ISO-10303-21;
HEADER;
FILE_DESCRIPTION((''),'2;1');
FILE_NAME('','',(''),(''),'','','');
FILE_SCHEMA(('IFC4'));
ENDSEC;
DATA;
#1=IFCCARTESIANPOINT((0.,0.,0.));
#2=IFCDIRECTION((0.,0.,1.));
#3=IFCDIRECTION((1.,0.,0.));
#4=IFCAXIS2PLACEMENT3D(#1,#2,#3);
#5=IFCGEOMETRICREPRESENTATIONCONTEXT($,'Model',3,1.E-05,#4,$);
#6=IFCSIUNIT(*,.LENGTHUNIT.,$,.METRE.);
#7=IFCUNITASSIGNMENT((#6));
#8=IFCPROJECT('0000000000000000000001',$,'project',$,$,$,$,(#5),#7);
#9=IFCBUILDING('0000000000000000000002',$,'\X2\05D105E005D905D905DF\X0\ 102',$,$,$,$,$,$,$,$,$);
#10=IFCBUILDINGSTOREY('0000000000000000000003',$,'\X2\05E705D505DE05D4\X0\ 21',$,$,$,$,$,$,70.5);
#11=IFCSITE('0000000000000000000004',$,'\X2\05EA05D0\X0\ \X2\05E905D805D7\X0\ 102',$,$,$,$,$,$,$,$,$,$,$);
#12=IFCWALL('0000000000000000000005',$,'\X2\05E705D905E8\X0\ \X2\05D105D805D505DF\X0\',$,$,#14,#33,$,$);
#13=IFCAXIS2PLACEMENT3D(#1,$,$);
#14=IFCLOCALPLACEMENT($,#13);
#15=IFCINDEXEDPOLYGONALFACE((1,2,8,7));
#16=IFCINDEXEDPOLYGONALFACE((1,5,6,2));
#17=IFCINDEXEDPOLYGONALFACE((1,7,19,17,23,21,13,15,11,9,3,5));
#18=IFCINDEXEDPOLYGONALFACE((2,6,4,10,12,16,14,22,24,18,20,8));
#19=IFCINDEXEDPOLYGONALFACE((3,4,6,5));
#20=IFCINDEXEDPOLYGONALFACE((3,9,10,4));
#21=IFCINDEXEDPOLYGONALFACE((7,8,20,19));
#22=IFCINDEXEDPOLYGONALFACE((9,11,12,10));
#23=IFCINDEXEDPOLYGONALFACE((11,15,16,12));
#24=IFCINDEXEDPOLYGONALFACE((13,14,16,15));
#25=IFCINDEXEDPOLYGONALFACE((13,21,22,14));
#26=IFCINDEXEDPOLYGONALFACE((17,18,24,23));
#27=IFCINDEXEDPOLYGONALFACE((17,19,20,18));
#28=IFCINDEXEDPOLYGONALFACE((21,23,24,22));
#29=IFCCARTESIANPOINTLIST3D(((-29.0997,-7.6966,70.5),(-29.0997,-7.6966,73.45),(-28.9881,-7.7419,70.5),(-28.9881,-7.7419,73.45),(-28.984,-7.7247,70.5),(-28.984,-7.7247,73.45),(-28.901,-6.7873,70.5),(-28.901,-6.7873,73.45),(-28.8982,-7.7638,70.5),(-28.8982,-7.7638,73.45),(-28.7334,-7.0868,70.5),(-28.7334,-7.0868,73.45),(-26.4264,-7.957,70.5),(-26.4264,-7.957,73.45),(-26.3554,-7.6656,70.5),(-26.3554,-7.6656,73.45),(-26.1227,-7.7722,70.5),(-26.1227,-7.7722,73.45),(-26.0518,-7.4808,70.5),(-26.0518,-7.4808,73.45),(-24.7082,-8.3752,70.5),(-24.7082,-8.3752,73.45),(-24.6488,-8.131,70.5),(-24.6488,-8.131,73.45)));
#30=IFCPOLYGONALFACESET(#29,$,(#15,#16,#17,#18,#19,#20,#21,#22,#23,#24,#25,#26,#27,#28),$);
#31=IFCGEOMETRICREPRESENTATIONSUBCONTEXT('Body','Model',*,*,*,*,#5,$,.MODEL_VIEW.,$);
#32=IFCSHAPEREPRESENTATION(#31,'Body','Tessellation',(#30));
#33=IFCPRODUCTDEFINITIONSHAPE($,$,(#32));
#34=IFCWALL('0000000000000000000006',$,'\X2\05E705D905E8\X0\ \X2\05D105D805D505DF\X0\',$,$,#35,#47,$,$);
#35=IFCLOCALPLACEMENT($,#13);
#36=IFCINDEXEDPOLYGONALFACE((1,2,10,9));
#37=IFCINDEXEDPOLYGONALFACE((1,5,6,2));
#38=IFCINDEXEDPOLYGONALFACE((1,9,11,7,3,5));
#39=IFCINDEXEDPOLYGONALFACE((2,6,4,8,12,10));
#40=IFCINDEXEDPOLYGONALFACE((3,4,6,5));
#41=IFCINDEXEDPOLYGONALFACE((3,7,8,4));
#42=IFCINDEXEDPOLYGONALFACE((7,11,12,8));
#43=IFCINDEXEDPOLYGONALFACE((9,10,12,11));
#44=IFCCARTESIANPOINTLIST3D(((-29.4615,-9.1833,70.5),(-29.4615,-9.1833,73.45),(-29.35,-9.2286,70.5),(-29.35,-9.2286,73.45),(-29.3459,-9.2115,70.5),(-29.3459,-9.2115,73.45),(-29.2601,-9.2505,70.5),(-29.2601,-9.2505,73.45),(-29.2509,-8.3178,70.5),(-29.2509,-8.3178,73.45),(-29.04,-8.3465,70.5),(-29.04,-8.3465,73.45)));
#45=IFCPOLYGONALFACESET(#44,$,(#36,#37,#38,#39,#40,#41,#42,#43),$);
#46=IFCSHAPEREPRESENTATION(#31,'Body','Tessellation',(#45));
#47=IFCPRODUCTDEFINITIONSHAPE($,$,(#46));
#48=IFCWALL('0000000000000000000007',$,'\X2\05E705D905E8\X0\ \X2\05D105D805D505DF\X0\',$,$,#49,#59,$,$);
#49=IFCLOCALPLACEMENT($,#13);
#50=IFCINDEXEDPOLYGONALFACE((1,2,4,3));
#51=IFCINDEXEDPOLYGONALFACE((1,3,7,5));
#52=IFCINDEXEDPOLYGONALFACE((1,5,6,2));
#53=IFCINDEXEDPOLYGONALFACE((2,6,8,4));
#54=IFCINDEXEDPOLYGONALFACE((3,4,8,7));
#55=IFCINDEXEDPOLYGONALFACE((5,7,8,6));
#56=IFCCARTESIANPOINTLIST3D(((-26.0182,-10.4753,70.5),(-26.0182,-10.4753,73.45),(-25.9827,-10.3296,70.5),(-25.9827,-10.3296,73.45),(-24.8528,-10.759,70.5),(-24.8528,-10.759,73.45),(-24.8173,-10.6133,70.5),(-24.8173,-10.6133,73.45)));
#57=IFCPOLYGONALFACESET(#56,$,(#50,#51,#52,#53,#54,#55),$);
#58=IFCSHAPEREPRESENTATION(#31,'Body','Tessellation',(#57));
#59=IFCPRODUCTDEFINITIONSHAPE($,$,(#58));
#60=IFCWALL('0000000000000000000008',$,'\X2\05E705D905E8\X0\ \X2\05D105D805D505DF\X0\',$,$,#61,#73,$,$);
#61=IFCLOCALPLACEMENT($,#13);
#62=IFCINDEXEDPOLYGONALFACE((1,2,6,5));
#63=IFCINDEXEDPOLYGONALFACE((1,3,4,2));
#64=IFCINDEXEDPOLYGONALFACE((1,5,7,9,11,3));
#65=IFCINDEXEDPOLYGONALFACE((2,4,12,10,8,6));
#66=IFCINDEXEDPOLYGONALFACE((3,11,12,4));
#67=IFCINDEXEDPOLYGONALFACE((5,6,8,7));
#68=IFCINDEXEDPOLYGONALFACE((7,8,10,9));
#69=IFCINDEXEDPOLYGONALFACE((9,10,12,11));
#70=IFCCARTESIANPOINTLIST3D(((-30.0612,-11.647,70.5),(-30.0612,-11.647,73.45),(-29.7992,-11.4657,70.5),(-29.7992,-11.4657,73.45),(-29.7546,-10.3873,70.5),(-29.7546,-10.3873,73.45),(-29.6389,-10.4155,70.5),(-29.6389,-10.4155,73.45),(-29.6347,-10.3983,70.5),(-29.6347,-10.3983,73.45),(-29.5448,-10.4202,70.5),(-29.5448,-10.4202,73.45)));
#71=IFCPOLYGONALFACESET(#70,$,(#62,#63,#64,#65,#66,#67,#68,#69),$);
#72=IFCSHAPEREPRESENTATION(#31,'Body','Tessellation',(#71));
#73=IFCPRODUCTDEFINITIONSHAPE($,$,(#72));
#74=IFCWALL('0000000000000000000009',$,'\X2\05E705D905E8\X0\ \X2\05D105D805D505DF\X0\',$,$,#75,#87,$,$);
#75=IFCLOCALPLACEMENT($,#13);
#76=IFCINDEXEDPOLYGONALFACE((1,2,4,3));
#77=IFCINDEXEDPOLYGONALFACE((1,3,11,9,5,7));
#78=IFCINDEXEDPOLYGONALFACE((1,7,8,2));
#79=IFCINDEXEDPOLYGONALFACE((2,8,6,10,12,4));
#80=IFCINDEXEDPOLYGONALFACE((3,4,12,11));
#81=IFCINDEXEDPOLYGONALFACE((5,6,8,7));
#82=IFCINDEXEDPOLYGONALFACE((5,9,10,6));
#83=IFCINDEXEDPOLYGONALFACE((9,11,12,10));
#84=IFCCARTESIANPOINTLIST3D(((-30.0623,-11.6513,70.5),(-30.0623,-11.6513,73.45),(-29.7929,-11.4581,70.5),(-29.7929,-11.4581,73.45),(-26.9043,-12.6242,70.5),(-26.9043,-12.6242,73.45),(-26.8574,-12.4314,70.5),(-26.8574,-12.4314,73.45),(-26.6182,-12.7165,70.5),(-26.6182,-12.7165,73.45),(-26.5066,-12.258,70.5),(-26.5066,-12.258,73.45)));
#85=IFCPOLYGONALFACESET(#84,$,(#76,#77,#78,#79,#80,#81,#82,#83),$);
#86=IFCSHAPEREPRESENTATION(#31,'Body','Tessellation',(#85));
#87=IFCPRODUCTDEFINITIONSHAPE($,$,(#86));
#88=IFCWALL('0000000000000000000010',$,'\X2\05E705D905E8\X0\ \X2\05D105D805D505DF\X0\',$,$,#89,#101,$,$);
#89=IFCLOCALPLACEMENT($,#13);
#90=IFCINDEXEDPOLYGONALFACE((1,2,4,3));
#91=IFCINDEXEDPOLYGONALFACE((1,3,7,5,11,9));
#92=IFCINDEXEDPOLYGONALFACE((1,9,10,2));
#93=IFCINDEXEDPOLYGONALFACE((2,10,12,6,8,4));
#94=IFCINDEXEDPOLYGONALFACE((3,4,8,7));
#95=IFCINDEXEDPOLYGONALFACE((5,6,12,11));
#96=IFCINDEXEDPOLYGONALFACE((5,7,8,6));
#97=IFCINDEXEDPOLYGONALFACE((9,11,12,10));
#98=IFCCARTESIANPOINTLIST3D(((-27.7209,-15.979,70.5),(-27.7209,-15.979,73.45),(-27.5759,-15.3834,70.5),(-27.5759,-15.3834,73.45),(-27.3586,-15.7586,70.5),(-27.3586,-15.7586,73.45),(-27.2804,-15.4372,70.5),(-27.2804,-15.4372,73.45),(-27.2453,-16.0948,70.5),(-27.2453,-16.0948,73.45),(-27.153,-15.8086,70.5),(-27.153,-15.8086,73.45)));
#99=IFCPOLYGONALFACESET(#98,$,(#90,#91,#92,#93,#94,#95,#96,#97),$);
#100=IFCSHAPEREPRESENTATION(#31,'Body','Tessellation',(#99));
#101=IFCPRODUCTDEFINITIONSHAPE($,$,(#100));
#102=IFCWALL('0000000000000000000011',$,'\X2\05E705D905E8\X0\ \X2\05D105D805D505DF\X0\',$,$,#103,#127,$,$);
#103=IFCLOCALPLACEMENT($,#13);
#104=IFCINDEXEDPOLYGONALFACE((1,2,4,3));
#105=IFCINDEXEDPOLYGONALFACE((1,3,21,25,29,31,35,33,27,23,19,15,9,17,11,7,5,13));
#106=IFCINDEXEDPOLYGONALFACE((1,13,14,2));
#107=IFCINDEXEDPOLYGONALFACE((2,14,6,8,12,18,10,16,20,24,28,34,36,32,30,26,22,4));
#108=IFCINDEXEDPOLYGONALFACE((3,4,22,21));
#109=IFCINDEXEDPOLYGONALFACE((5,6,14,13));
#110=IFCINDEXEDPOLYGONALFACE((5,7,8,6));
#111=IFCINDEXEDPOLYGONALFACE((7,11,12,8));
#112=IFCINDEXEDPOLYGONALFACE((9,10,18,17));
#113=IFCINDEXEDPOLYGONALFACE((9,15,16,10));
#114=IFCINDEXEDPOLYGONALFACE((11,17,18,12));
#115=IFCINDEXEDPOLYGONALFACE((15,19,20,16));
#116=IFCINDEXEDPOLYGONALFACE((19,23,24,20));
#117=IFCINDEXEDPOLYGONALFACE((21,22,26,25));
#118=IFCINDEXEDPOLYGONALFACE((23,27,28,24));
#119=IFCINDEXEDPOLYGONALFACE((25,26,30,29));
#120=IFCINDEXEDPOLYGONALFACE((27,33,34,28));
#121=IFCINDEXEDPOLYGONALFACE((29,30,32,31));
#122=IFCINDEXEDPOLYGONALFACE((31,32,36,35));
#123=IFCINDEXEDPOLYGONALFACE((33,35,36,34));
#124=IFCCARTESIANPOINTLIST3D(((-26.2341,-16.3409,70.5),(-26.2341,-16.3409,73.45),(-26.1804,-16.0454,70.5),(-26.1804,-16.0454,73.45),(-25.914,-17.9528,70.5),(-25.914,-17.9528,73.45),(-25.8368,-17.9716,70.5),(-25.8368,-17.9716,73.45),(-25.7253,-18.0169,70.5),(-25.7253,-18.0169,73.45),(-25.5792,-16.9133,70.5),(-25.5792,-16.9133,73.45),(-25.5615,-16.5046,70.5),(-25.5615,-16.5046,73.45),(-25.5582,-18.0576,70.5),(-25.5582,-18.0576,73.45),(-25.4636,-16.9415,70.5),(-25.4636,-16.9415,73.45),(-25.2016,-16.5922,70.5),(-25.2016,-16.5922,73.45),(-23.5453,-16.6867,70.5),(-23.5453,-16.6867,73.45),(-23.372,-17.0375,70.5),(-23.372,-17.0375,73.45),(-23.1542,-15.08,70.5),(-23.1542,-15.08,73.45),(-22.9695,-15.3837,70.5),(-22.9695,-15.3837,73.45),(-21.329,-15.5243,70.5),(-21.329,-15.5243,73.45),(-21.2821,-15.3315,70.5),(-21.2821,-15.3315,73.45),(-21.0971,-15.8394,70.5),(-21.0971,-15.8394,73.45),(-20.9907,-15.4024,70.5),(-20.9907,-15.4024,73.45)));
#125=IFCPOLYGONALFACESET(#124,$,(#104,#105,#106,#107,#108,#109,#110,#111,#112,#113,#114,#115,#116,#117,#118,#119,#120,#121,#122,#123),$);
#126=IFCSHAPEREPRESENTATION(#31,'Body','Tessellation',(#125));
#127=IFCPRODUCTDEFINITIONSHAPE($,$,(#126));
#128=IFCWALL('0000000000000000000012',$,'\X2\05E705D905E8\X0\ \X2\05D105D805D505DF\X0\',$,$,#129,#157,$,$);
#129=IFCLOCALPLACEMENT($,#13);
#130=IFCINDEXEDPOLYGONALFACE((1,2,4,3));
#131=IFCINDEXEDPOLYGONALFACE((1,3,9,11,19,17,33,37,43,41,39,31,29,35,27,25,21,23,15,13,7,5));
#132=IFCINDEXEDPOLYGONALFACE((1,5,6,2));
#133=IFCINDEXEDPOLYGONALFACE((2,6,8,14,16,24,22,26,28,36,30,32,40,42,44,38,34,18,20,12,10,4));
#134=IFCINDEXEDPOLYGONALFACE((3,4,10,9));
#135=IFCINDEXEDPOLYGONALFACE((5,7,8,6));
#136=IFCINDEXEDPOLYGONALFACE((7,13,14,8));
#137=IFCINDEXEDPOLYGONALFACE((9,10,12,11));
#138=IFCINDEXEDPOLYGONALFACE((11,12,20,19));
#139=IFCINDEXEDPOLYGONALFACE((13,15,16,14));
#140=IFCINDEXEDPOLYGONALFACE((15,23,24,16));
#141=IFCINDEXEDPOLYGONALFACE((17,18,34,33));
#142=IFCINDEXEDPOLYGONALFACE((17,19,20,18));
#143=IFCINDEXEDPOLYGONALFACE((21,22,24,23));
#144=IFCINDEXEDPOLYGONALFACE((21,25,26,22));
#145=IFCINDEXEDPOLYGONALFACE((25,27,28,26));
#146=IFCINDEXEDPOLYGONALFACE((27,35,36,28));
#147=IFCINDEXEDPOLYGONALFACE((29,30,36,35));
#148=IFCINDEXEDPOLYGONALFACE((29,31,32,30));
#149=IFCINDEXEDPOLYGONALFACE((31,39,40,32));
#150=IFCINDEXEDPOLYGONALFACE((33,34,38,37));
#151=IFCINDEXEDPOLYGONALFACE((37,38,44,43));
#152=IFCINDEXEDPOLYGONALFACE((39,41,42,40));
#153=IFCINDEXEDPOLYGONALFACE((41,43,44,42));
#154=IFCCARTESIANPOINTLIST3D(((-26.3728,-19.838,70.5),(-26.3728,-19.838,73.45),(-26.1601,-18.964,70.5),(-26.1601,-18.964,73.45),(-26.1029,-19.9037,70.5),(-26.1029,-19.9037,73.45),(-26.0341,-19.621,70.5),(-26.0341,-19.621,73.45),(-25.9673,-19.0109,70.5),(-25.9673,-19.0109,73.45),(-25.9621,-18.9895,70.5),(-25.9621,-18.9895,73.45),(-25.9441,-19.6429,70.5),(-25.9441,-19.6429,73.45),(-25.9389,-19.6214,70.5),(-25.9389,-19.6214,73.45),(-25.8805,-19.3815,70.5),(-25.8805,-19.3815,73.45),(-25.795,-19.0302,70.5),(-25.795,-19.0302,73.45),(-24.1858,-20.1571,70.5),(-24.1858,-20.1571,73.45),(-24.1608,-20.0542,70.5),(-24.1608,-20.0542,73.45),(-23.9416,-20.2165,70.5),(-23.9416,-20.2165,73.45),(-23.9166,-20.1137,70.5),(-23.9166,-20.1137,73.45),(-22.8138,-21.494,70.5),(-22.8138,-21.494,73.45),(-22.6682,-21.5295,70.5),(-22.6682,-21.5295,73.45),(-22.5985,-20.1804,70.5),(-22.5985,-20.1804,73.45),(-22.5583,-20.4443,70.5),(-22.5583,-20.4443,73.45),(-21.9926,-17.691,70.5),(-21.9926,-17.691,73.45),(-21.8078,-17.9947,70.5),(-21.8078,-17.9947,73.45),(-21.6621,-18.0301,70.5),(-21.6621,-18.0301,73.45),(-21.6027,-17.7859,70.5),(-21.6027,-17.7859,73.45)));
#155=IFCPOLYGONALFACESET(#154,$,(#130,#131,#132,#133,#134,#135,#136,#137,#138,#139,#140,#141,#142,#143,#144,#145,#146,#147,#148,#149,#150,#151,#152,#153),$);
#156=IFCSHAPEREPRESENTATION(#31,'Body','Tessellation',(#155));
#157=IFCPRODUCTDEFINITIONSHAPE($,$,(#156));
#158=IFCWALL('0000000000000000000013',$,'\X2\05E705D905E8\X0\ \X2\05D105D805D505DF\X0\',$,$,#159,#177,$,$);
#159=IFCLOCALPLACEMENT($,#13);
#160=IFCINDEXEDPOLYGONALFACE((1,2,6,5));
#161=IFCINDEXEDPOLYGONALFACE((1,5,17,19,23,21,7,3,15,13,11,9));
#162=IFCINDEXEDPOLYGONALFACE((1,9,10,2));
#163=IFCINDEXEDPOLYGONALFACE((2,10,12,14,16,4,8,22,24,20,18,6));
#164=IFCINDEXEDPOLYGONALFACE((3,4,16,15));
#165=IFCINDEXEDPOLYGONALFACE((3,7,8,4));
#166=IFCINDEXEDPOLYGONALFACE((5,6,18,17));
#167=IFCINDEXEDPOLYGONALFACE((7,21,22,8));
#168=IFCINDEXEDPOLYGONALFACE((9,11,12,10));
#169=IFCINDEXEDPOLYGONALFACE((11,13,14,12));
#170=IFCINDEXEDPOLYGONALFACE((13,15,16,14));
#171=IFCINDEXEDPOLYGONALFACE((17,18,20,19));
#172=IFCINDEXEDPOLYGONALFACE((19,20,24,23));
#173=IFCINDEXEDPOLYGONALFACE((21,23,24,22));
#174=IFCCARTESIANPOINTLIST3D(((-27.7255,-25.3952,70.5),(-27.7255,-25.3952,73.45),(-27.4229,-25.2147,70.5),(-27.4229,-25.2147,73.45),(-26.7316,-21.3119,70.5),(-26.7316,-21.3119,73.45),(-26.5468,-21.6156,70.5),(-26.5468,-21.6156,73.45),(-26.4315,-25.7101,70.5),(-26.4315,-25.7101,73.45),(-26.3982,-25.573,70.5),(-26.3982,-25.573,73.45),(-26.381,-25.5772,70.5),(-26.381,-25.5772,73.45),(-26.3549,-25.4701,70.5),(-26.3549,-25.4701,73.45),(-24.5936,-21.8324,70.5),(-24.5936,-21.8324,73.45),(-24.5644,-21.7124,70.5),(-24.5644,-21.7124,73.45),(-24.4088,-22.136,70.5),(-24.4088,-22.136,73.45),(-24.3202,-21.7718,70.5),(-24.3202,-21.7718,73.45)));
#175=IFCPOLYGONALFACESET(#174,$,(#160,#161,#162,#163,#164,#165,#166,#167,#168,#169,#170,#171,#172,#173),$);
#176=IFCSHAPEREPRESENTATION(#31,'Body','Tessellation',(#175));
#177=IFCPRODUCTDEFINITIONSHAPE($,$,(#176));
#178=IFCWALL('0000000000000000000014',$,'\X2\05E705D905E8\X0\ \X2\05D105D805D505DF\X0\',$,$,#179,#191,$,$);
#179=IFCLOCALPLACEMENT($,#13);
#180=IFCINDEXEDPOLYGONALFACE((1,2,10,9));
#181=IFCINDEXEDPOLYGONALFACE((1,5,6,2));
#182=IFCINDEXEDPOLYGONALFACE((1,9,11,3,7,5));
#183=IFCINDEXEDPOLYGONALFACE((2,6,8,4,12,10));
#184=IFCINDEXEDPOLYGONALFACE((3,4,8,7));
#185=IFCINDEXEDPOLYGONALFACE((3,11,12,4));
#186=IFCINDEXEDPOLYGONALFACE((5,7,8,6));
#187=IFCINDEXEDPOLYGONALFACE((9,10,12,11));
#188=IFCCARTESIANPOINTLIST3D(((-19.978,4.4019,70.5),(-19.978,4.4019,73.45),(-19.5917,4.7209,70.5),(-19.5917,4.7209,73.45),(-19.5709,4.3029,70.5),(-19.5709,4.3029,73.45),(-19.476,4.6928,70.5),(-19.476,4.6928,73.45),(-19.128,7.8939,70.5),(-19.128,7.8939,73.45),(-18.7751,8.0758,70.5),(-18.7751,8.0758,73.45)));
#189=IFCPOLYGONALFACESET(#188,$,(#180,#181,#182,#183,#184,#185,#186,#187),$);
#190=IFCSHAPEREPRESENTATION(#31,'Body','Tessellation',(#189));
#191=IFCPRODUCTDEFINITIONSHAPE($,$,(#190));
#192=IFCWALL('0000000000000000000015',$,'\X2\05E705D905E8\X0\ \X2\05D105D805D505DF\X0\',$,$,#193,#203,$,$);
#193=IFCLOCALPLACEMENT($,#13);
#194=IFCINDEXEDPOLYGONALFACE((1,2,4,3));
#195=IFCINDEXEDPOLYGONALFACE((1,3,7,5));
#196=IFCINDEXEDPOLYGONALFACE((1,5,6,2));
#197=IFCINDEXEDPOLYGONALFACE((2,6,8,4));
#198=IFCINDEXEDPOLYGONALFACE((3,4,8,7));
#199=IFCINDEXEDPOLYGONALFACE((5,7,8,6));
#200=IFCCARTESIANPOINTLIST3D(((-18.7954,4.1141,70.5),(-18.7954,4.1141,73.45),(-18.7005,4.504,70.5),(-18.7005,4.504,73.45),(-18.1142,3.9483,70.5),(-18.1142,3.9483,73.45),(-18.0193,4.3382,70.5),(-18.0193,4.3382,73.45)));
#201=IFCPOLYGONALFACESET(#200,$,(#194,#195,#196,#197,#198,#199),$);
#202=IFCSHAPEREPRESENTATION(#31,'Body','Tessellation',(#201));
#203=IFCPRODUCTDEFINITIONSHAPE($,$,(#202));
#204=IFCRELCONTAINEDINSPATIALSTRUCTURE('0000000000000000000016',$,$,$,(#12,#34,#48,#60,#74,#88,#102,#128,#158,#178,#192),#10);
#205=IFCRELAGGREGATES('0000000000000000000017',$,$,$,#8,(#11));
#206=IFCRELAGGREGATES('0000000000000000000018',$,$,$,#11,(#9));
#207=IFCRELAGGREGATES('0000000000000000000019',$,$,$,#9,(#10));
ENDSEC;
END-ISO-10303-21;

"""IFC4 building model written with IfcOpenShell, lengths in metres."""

from ifc_helpers import new_model, si_unit, frame, origin_with_axes, context, subcontext, project, spatial, polyline, outline, extrude, element, save


model = new_model("IFC4")

# Units and contexts
model_context = context("Model", 3, precision=1e-05, world=origin_with_axes())
body_context = subcontext(model_context, "Body", "Model", "MODEL_VIEW")
ifc_project = project(units=[si_unit("LENGTHUNIT", "METRE")], contexts=[model_context])

# Site, building, storey
site = spatial("IfcSite", under=ifc_project, Name="תא שטח 102")
building = spatial("IfcBuilding", under=site, Name="בניין 102")
storey = spatial("IfcBuildingStorey", under=building, Name="קומה 21", Elevation=70.5)

# Walls
element("IfcWall", 1, inside=storey, Name="קיר בטון", context=body_context, shape_type="SweptSolid", body=[
    extrude(outline(polyline([(-28.984, -7.7247), (-28.9881, -7.7419), (-28.8982, -7.7638), (-28.7334, -7.0868), (-26.3554, -7.6656), (-26.4264, -7.957), (-24.7082, -8.3752), (-24.6488, -8.131), (-26.1227, -7.7722), (-26.0518, -7.4808), (-28.901, -6.7873), (-29.0997, -7.6966), (-28.984, -7.7247)])), frame((0.0, 0.0, 70.5)), (0.0, 0.0, 1.0), 2.95),
])
element("IfcWall", 2, inside=storey, Name="קיר בטון", context=body_context, shape_type="SweptSolid", body=[
    extrude(outline(polyline([(-29.3459, -9.2115), (-29.35, -9.2286), (-29.2601, -9.2505), (-29.04, -8.3465), (-29.2509, -8.3178), (-29.4615, -9.1833), (-29.3459, -9.2115)])), frame((0.0, 0.0, 70.5)), (0.0, 0.0, 1.0), 2.95),
])
element("IfcWall", 3, inside=storey, Name="קיר בטון", context=body_context, shape_type="SweptSolid", body=[
    extrude(outline(polyline([(-25.9827, -10.3296), (-26.0182, -10.4753), (-24.8528, -10.759), (-24.8173, -10.6133), (-25.9827, -10.3296)])), frame((0.0, 0.0, 70.5)), (0.0, 0.0, 1.0), 2.95),
])
element("IfcWall", 4, inside=storey, Name="קיר בטון", context=body_context, shape_type="SweptSolid", body=[
    extrude(outline(polyline([(-29.7992, -11.4657), (-29.5448, -10.4202), (-29.6347, -10.3983), (-29.6389, -10.4155), (-29.7546, -10.3873), (-30.0612, -11.647), (-29.7992, -11.4657)])), frame((0.0, 0.0, 70.5)), (0.0, 0.0, 1.0), 2.95),
])
element("IfcWall", 5, inside=storey, Name="קיר בטון", context=body_context, shape_type="SweptSolid", body=[
    extrude(outline(polyline([(-26.5066, -12.258), (-29.7929, -11.4581), (-30.0623, -11.6513), (-26.8574, -12.4314), (-26.9043, -12.6242), (-26.6182, -12.7165), (-26.5066, -12.258)])), frame((0.0, 0.0, 70.5)), (0.0, 0.0, 1.0), 2.95),
])
element("IfcWall", 6, inside=storey, Name="קיר בטון", context=body_context, shape_type="SweptSolid", body=[
    extrude(outline(polyline([(-27.7209, -15.979), (-27.2453, -16.0948), (-27.153, -15.8086), (-27.3586, -15.7586), (-27.2804, -15.4372), (-27.5759, -15.3834), (-27.7209, -15.979)])), frame((0.0, 0.0, 70.5)), (0.0, 0.0, 1.0), 2.95),
])
element("IfcWall", 7, inside=storey, Name="קיר בטון", context=body_context, shape_type="SweptSolid", body=[
    extrude(outline(polyline([(-25.5582, -18.0576), (-25.2016, -16.5922), (-23.372, -17.0375), (-22.9695, -15.3837), (-21.0971, -15.8394), (-20.9907, -15.4024), (-21.2821, -15.3315), (-21.329, -15.5243), (-23.1542, -15.08), (-23.5453, -16.6867), (-26.1804, -16.0454), (-26.2341, -16.3409), (-25.5615, -16.5046), (-25.914, -17.9528), (-25.8368, -17.9716), (-25.5792, -16.9133), (-25.4636, -16.9415), (-25.7253, -18.0169), (-25.5582, -18.0576)])), frame((0.0, 0.0, 70.5)), (0.0, 0.0, 1.0), 2.95),
])
element("IfcWall", 8, inside=storey, Name="קיר בטון", context=body_context, shape_type="SweptSolid", body=[
    extrude(outline(polyline([(-25.9673, -19.0109), (-26.1601, -18.964), (-26.3728, -19.838), (-26.1029, -19.9037), (-26.0341, -19.621), (-25.9441, -19.6429), (-25.9389, -19.6214), (-24.1608, -20.0542), (-24.1858, -20.1571), (-23.9416, -20.2165), (-23.9166, -20.1137), (-22.5583, -20.4443), (-22.8138, -21.494), (-22.6682, -21.5295), (-21.8078, -17.9947), (-21.6621, -18.0301), (-21.6027, -17.7859), (-21.9926, -17.691), (-22.5985, -20.1804), (-25.8805, -19.3815), (-25.795, -19.0302), (-25.9621, -18.9895), (-25.9673, -19.0109)])), frame((0.0, 0.0, 70.5)), (0.0, 0.0, 1.0), 2.95),
])
element("IfcWall", 9, inside=storey, Name="קיר בטון", context=body_context, shape_type="SweptSolid", body=[
    extrude(outline(polyline([(-27.7255, -25.3952), (-26.4315, -25.7101), (-26.3982, -25.573), (-26.381, -25.5772), (-26.3549, -25.4701), (-27.4229, -25.2147), (-26.5468, -21.6156), (-24.4088, -22.136), (-24.3202, -21.7718), (-24.5644, -21.7124), (-24.5936, -21.8324), (-26.7316, -21.3119), (-27.7255, -25.3952)])), frame((0.0, 0.0, 70.5)), (0.0, 0.0, 1.0), 2.95),
])
element("IfcWall", 10, inside=storey, Name="קיר בטון", context=body_context, shape_type="SweptSolid", body=[
    extrude(outline(polyline([(-18.7751, 8.0758), (-19.128, 7.8939), (-19.978, 4.4019), (-19.5709, 4.3029), (-19.476, 4.6928), (-19.5917, 4.7209), (-18.7751, 8.0758)])), frame((0.0, 0.0, 70.5)), (0.0, 0.0, 1.0), 2.95),
])
element("IfcWall", 11, inside=storey, Name="קיר בטון", context=body_context, shape_type="SweptSolid", body=[
    extrude(outline(polyline([(-18.7005, 4.504), (-18.7954, 4.1141), (-18.1142, 3.9483), (-18.0193, 4.3382), (-18.7005, 4.504)])), frame((0.0, 0.0, 70.5)), (0.0, 0.0, 1.0), 2.95),
])

save(model, "model.ifc")
